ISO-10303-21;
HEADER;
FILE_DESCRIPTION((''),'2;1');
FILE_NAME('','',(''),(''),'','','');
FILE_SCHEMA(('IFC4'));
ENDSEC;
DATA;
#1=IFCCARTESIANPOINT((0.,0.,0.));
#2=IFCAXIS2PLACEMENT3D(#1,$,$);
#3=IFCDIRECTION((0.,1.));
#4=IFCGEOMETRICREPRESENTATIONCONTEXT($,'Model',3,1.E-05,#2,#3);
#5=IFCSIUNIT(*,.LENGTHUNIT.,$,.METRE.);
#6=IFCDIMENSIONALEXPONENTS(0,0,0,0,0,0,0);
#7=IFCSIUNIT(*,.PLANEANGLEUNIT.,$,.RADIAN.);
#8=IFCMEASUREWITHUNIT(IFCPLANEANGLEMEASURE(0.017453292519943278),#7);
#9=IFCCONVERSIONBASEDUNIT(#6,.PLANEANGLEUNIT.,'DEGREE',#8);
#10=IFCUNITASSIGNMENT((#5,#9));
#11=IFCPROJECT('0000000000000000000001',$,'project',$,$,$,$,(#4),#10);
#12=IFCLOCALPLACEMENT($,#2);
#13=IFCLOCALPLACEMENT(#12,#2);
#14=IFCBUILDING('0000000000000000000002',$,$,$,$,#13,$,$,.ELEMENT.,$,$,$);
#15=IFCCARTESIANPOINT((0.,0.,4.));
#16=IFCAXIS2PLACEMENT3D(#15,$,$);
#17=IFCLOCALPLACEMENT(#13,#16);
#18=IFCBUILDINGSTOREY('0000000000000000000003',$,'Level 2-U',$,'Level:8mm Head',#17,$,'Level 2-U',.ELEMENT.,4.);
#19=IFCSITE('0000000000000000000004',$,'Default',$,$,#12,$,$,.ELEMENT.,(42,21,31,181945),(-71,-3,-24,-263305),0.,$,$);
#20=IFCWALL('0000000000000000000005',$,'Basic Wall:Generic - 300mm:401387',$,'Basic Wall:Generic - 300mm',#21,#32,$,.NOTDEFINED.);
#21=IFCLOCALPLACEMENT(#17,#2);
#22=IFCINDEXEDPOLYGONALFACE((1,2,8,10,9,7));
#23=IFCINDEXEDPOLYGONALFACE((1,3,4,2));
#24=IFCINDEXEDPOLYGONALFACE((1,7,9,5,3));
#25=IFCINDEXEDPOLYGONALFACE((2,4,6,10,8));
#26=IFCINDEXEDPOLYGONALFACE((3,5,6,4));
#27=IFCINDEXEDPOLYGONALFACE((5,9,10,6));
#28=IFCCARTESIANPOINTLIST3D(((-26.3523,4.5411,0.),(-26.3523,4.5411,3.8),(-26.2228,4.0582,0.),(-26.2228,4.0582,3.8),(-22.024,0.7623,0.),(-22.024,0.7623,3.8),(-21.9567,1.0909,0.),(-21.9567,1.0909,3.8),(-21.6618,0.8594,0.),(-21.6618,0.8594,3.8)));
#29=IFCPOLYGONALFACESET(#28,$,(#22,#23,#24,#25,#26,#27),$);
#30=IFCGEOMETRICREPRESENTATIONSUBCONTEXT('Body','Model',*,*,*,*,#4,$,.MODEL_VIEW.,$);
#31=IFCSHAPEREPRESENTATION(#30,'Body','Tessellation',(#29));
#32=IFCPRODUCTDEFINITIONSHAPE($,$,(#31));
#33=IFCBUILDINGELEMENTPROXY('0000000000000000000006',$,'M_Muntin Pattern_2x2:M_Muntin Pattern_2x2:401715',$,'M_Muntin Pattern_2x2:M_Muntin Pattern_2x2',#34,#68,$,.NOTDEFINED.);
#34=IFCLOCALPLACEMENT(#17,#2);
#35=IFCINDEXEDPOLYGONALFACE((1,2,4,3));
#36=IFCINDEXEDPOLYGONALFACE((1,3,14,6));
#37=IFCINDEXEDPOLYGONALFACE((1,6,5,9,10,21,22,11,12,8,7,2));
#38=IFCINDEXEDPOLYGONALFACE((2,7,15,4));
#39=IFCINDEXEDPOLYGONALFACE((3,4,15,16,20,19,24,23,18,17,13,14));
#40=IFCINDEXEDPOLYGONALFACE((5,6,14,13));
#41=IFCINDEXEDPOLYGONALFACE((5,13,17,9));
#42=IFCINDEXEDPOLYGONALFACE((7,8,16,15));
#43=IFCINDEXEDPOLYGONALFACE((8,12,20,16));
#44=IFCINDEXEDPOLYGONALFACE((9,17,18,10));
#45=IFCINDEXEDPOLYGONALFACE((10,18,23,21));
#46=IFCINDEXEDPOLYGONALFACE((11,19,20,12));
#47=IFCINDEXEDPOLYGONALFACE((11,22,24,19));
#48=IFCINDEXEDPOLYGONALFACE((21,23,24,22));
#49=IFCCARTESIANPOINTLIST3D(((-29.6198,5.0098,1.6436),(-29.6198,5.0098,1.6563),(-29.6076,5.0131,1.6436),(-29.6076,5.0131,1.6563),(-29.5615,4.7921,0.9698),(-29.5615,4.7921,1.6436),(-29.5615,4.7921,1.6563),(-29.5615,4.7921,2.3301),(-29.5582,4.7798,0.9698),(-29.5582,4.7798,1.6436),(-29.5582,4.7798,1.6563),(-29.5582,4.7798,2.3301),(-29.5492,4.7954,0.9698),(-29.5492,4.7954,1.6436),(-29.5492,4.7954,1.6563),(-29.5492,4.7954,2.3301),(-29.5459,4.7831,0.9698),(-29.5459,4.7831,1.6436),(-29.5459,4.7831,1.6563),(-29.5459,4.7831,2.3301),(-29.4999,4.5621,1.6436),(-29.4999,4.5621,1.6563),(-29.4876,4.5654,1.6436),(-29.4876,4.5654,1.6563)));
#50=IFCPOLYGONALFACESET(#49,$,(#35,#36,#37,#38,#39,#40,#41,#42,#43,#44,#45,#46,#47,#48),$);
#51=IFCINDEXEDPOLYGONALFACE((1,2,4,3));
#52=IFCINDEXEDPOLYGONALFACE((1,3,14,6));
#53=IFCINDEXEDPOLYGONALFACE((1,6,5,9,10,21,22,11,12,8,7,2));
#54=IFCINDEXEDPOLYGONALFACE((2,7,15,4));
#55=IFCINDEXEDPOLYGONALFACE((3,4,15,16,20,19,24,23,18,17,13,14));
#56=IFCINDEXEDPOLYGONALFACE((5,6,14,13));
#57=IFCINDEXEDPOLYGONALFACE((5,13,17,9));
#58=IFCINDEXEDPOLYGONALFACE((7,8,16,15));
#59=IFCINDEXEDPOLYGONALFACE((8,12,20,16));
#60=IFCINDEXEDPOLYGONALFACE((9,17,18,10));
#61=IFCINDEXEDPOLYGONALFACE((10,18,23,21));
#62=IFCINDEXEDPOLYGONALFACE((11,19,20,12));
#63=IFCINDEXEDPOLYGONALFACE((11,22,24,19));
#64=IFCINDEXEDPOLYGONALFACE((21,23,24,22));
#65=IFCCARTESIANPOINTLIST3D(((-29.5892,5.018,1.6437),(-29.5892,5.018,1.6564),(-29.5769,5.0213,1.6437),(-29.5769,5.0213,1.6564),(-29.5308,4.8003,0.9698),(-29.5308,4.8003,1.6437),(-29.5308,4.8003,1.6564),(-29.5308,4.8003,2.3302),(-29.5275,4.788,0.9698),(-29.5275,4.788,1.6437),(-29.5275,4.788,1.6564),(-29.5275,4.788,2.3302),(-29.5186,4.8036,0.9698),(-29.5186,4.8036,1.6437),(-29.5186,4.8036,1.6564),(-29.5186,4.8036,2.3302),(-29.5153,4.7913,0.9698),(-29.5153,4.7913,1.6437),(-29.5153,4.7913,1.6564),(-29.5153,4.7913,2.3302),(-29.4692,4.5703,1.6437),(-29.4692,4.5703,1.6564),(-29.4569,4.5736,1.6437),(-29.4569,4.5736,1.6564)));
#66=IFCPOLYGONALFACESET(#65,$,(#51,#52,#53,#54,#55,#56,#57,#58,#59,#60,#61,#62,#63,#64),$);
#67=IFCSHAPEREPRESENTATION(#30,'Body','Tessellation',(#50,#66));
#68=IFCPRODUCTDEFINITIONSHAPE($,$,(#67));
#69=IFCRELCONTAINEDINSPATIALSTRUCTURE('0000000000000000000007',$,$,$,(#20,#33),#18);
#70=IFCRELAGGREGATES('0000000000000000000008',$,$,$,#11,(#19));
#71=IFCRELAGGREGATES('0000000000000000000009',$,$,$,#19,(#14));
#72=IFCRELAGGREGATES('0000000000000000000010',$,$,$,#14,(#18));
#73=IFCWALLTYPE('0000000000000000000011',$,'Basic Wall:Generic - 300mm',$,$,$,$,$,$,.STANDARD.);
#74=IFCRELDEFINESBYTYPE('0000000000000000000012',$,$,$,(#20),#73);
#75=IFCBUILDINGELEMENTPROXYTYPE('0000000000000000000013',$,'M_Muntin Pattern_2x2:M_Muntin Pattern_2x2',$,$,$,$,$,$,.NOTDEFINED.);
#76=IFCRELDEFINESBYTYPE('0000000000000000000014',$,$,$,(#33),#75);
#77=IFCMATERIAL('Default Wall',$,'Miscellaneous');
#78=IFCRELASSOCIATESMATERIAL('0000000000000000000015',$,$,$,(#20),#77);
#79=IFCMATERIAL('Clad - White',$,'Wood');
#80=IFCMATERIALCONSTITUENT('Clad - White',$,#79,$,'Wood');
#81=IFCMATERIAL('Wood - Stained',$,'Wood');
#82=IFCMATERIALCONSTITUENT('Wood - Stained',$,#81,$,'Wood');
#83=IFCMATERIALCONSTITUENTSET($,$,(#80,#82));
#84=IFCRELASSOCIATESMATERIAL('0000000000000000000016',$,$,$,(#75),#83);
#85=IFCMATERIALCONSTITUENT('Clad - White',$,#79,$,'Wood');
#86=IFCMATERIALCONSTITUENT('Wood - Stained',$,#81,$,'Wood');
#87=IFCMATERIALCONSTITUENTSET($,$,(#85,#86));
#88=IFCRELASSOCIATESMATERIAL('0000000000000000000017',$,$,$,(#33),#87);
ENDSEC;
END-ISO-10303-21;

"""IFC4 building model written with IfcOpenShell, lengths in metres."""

from ifc_helpers import new_model, entity, si_unit, converted_unit, direction, frame, origin, place, context, subcontext, project, spatial, indexed_curve, outline, extrude, source, transform, mapped, material, constituent, constituent_set, type_object, type_shapes, element, save


model = new_model("IFC4")

# Units and contexts
model_context = context("Model", 3, precision=1e-05, world=origin(), true_north=direction((0.0, 1.0)))
body_context = subcontext(model_context, "Body", "Model", "MODEL_VIEW")
ifc_project = project(units=[si_unit("LENGTHUNIT", "METRE"), converted_unit("PLANEANGLEUNIT", "DEGREE", entity("IfcPlaneAngleMeasure", 0.017453292519943278), si_unit("PLANEANGLEUNIT", "RADIAN"), dimensions=[0, 0, 0, 0, 0, 0, 0])], contexts=[model_context])

# Site, building, storey
site_placement = place(None, origin())
site = spatial("IfcSite", under=ifc_project, at=site_placement, Name="Default", CompositionType="ELEMENT", RefLatitude=(42, 21, 31, 181945), RefLongitude=(-71, -3, -24, -263305), RefElevation=0.0)
building_placement = place(site_placement, origin())
building = spatial("IfcBuilding", under=site, at=building_placement, CompositionType="ELEMENT")
storey_placement = place(building_placement, frame((0.0, 0.0, 4.0)))
storey = spatial("IfcBuildingStorey", under=building, at=storey_placement, Name="Level 2-U", ObjectType="Level:8mm Head", LongName="Level 2-U", CompositionType="ELEMENT", Elevation=4.0)

# Wall
ifc_material_1 = material(Name="Default Wall", Category="Miscellaneous")
wall_type_1 = type_object("IfcWallType", Name="Basic Wall:Generic - 300mm", PredefinedType="STANDARD")
wall_1_placement = place(storey_placement, frame((-26.4449, 4.4232, 0.0), z_axis=(0.0, 0.0, 1.0), x_axis=(0.786611, -0.617449, 0.0)))
element("IfcWall", 1, at=wall_1_placement, inside=storey, type_object=wall_type_1, material=ifc_material_1, Name="Basic Wall:Generic - 300mm:401387", ObjectType="Basic Wall:Generic - 300mm", PredefinedType="NOTDEFINED", context=body_context, shape_type="SweptSolid", body=[
    extrude(outline(indexed_curve([(5.7379, -0.15), (5.9629, 0.15), (5.5879, 0.15), (0.0, 0.15), (0.4, -0.15), (5.7379, -0.15)], self_intersect=False)), origin(), (0.0, 0.0, 1.0), 3.8),
])

# Building element proxy
ifc_material_2 = material(Name="Clad - White", Category="Wood")
ifc_constituent_1 = constituent(ifc_material_2, Name="Clad - White", Category="Wood")
ifc_material_3 = material(Name="Wood - Stained", Category="Wood")
ifc_constituent_2 = constituent(ifc_material_3, Name="Wood - Stained", Category="Wood")
ifc_constituent_set_1 = constituent_set(constituents=[ifc_constituent_1, ifc_constituent_2])
ifc_constituent_3 = constituent(ifc_material_2, Name="Clad - White", Category="Wood")
ifc_constituent_4 = constituent(ifc_material_3, Name="Wood - Stained", Category="Wood")
ifc_constituent_set_2 = constituent_set(constituents=[ifc_constituent_3, ifc_constituent_4])
building_element_proxy_type = type_object("IfcBuildingElementProxyType", Name="M_Muntin Pattern_2x2:M_Muntin Pattern_2x2", PredefinedType="NOTDEFINED", material=ifc_constituent_set_2)
shared_shape_1 = source(origin(), body_context, "Body", "SweptSolid", [
    extrude(outline(indexed_curve([(0.0064, -0.0064), (0.6801, -0.0064), (0.6801, 0.0063), (0.0064, 0.0063), (0.0064, 0.2317), (-0.0063, 0.2317), (-0.0063, 0.0063), (-0.6802, 0.0063), (-0.6802, -0.0064), (-0.0063, -0.0064), (-0.0063, -0.2317), (0.0064, -0.2317), (0.0064, -0.0064)], self_intersect=False)), frame((0.0, 0.0095, 0.6801), z_axis=(0.0, 1.0, 0.0), x_axis=(0.0, 0.0, 1.0)), (0.0, 0.0, 1.0), 0.0127),
    extrude(outline(indexed_curve([(0.0064, -0.0064), (0.6802, -0.0064), (0.6802, 0.0063), (0.0064, 0.0063), (0.0064, 0.2317), (-0.0063, 0.2317), (-0.0063, 0.0063), (-0.6802, 0.0063), (-0.6802, -0.0064), (-0.0063, -0.0064), (-0.0063, -0.2317), (0.0064, -0.2317), (0.0064, -0.0064)], self_intersect=False)), frame((0.0, -0.0222, 0.6802), z_axis=(0.0, 1.0, 0.0), x_axis=(0.0, 0.0, 1.0)), (0.0, 0.0, 1.0), 0.0127),
])
type_shapes(building_element_proxy_type, [shared_shape_1])
proxy_placement = place(storey_placement, frame((-29.5384, 4.7917, 0.9698), z_axis=(0.0, 0.0, 1.0), x_axis=(-0.258819, 0.965926, 0.0)))
element("IfcBuildingElementProxy", 2, at=proxy_placement, inside=storey, type_object=building_element_proxy_type, material=ifc_constituent_set_1, Name="M_Muntin Pattern_2x2:M_Muntin Pattern_2x2:401715", ObjectType="M_Muntin Pattern_2x2:M_Muntin Pattern_2x2", PredefinedType="NOTDEFINED", context=body_context, shape_type="MappedRepresentation", body=[
    mapped(shared_shape_1, transform((0.0, 0.0, 0.0), scale=1.0)),
])

save(model, "model.ifc")
